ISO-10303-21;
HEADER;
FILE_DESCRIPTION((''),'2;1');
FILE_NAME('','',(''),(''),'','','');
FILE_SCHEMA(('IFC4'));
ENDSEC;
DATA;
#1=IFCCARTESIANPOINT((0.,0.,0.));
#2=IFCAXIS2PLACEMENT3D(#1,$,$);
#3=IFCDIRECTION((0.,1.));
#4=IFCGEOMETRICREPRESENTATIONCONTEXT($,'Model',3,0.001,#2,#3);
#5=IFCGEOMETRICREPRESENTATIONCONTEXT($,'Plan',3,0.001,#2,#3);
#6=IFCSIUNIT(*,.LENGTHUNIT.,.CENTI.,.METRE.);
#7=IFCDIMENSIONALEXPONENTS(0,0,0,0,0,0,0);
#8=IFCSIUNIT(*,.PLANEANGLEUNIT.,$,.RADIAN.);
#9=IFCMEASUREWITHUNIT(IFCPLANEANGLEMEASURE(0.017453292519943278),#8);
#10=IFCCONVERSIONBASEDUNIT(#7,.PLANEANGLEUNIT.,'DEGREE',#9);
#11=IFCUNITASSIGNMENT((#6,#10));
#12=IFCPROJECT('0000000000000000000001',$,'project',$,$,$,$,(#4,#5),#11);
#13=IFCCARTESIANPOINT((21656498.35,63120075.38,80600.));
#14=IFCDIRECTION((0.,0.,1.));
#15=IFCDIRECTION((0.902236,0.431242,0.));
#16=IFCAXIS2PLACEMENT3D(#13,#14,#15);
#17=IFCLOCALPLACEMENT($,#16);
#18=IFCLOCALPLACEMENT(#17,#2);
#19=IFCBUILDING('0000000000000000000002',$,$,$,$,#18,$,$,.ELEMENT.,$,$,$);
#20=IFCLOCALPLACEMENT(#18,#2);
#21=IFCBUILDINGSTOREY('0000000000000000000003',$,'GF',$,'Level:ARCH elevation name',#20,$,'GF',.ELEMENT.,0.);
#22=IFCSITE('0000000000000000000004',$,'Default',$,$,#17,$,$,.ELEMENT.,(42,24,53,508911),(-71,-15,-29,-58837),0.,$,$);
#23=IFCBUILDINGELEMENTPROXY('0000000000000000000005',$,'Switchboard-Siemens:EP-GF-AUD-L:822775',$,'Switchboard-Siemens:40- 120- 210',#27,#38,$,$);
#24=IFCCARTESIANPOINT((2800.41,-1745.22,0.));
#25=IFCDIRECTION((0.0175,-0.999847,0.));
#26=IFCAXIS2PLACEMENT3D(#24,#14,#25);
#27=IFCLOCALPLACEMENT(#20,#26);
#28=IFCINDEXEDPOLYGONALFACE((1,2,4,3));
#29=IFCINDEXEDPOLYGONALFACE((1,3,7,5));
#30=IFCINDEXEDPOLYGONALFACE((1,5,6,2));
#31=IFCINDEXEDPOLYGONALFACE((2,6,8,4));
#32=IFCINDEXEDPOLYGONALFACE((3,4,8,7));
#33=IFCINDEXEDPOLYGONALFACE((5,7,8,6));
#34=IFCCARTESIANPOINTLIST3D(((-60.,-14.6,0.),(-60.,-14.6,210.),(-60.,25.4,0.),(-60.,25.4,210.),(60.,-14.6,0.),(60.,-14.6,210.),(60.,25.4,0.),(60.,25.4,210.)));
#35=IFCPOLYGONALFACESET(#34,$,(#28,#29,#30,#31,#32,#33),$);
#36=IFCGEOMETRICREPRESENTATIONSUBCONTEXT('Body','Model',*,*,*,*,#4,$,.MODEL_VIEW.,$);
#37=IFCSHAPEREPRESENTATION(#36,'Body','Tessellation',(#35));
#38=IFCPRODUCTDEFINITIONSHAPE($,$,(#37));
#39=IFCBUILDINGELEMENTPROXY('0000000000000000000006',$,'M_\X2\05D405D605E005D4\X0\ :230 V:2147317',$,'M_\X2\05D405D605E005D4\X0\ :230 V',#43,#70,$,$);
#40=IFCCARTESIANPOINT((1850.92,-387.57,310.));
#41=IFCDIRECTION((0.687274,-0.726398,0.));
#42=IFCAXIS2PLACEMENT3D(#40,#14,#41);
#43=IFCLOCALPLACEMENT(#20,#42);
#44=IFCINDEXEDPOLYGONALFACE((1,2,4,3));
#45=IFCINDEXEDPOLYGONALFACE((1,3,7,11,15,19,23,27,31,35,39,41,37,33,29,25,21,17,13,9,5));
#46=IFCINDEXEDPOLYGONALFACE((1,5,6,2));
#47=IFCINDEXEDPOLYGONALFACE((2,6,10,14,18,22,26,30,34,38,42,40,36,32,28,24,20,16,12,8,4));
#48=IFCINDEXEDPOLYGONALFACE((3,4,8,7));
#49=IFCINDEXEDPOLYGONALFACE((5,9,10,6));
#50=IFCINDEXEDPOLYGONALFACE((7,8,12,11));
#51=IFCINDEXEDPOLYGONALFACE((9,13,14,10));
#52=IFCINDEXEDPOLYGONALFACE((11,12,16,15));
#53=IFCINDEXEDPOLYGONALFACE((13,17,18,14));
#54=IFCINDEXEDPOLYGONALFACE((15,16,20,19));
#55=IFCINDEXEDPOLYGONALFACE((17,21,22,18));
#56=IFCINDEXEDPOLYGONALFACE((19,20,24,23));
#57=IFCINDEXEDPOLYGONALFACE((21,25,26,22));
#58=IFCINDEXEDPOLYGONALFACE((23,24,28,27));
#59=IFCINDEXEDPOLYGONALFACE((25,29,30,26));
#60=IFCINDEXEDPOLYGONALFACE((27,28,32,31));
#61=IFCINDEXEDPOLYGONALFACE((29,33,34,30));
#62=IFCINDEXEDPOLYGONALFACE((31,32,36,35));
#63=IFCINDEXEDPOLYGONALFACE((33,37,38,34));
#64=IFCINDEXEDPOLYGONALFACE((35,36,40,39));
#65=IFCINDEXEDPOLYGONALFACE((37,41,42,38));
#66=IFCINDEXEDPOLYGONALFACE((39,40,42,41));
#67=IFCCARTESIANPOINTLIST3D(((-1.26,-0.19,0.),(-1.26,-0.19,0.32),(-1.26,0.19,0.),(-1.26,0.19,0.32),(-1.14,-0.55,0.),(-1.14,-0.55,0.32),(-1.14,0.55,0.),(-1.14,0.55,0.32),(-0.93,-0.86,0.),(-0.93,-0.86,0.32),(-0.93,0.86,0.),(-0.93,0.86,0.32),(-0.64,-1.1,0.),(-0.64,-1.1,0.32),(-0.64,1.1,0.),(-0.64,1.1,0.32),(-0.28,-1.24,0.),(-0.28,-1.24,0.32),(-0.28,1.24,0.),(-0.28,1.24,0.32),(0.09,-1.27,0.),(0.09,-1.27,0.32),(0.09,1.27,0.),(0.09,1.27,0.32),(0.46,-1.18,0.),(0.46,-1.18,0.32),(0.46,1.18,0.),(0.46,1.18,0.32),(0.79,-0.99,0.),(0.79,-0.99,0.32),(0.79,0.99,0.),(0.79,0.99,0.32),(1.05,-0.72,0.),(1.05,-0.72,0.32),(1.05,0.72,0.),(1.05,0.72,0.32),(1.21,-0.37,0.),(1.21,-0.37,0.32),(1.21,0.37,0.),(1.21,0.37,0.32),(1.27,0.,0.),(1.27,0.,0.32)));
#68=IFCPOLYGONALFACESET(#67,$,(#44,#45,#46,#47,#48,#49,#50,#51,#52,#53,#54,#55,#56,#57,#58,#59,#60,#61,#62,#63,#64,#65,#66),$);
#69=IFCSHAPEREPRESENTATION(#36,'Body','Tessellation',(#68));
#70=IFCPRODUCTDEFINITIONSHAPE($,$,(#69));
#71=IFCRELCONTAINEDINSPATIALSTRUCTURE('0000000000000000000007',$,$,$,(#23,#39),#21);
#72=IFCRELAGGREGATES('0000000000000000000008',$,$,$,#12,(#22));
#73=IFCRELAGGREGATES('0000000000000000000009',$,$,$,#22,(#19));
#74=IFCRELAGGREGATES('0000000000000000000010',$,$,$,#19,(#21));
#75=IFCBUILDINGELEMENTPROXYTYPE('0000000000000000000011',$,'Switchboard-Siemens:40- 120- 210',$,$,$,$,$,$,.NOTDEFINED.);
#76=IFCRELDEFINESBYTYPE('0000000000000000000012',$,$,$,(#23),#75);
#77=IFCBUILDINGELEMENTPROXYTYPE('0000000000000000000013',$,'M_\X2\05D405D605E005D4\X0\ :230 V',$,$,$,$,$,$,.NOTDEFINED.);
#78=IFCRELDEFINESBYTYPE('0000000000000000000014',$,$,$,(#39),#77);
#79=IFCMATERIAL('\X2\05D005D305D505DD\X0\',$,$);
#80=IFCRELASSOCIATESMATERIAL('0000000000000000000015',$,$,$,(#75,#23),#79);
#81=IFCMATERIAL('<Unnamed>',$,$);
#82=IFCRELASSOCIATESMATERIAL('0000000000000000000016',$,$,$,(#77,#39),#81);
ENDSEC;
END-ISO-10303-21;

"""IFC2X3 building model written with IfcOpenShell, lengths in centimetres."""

from ifc_helpers import new_model, entity, si_unit, converted_unit, direction, frame, frame_2d, origin, origin_2d_with_axis, place, context, subcontext, project, spatial, rectangle, circle, extrude, source, transform, mapped, material, type_object, type_shapes, element, save


model = new_model("IFC2X3")

# Units and contexts
model_context = context("Model", 3, precision=0.001, world=origin(), true_north=direction((0.0, 1.0)))
plan_context = context("Plan", 3, precision=0.001, world=origin(), true_north=direction((0.0, 1.0)))
body_context = subcontext(model_context, "Body", "Model", "MODEL_VIEW")
ifc_project = project(units=[si_unit("LENGTHUNIT", "METRE", prefix="CENTI"), converted_unit("PLANEANGLEUNIT", "DEGREE", entity("IfcPlaneAngleMeasure", 0.017453292519943278), si_unit("PLANEANGLEUNIT", "RADIAN"), dimensions=[0, 0, 0, 0, 0, 0, 0])], contexts=[model_context, plan_context])

# Site, building, storey
site_placement = place(None, frame((21656498.35, 63120075.38, 80600.0), z_axis=(0.0, 0.0, 1.0), x_axis=(0.902236, 0.431242, 0.0)))
site = spatial("IfcSite", under=ifc_project, at=site_placement, Name="Default", CompositionType="ELEMENT", RefLatitude=(42, 24, 53, 508911), RefLongitude=(-71, -15, -29, -58837), RefElevation=0.0)
building_placement = place(site_placement, origin())
building = spatial("IfcBuilding", under=site, at=building_placement, CompositionType="ELEMENT")
storey_placement = place(building_placement, origin())
storey = spatial("IfcBuildingStorey", under=building, at=storey_placement, Name="GF", ObjectType="Level:ARCH elevation name", LongName="GF", CompositionType="ELEMENT", Elevation=0.0)

# Building element proxies
ifc_material_1 = material(Name="אדום")
building_element_proxy_type_1 = type_object("IfcBuildingElementProxyType", Name="Switchboard-Siemens:40- 120- 210", PredefinedType="NOTDEFINED", material=ifc_material_1)
shared_shape_1 = source(origin(), body_context, "Body", "SweptSolid", [
    extrude(rectangle(XDim=120.0, YDim=40.0, at=origin_2d_with_axis()), frame((0.0, 5.4, 0.0), z_axis=(0.0, 0.0, 1.0), x_axis=(-1.0, 0.0, 0.0)), (0.0, 0.0, 1.0), 210.0),
])
type_shapes(building_element_proxy_type_1, [shared_shape_1])
proxy_1_placement = place(storey_placement, frame((2800.41, -1745.22, 0.0), z_axis=(0.0, 0.0, 1.0), x_axis=(0.0175, -0.999847, 0.0)))
element("IfcBuildingElementProxy", 1, at=proxy_1_placement, inside=storey, type_object=building_element_proxy_type_1, material=ifc_material_1, Name="Switchboard-Siemens:EP-GF-AUD-L:822775", ObjectType="Switchboard-Siemens:40- 120- 210", context=body_context, shape_type="MappedRepresentation", body=[
    mapped(shared_shape_1, transform((0.0, 0.0, 0.0), scale=1.0)),
])
ifc_material_2 = material(Name="<Unnamed>")
building_element_proxy_type_2 = type_object("IfcBuildingElementProxyType", Name="M_הזנה :230 V", PredefinedType="NOTDEFINED", material=ifc_material_2)
shared_shape_2 = source(origin(), body_context, "Body", "SweptSolid", [
    extrude(circle(Radius=1.27, at=frame_2d((0.0, 0.0), x_axis=(1.0, 0.0))), origin(), (0.0, 0.0, 1.0), 0.32),
])
type_shapes(building_element_proxy_type_2, [shared_shape_2])
for number, where, z_axis, x_axis, name in (
    (2, (1850.92, -387.57, 310.0), (0.0, 0.0, 1.0), (0.687274, -0.726398, 0.0), "M_הזנה :230 V:2147317"),
):
    element("IfcBuildingElementProxy", number, at=place(storey_placement, frame(where, z_axis=z_axis, x_axis=x_axis)), inside=storey, type_object=building_element_proxy_type_2, material=ifc_material_2, Name=name, ObjectType="M_הזנה :230 V", context=body_context, shape_type="MappedRepresentation", body=[
        mapped(shared_shape_2, transform((0.0, 0.0, 0.0), scale=1.0)),
    ])

save(model, "model.ifc")
